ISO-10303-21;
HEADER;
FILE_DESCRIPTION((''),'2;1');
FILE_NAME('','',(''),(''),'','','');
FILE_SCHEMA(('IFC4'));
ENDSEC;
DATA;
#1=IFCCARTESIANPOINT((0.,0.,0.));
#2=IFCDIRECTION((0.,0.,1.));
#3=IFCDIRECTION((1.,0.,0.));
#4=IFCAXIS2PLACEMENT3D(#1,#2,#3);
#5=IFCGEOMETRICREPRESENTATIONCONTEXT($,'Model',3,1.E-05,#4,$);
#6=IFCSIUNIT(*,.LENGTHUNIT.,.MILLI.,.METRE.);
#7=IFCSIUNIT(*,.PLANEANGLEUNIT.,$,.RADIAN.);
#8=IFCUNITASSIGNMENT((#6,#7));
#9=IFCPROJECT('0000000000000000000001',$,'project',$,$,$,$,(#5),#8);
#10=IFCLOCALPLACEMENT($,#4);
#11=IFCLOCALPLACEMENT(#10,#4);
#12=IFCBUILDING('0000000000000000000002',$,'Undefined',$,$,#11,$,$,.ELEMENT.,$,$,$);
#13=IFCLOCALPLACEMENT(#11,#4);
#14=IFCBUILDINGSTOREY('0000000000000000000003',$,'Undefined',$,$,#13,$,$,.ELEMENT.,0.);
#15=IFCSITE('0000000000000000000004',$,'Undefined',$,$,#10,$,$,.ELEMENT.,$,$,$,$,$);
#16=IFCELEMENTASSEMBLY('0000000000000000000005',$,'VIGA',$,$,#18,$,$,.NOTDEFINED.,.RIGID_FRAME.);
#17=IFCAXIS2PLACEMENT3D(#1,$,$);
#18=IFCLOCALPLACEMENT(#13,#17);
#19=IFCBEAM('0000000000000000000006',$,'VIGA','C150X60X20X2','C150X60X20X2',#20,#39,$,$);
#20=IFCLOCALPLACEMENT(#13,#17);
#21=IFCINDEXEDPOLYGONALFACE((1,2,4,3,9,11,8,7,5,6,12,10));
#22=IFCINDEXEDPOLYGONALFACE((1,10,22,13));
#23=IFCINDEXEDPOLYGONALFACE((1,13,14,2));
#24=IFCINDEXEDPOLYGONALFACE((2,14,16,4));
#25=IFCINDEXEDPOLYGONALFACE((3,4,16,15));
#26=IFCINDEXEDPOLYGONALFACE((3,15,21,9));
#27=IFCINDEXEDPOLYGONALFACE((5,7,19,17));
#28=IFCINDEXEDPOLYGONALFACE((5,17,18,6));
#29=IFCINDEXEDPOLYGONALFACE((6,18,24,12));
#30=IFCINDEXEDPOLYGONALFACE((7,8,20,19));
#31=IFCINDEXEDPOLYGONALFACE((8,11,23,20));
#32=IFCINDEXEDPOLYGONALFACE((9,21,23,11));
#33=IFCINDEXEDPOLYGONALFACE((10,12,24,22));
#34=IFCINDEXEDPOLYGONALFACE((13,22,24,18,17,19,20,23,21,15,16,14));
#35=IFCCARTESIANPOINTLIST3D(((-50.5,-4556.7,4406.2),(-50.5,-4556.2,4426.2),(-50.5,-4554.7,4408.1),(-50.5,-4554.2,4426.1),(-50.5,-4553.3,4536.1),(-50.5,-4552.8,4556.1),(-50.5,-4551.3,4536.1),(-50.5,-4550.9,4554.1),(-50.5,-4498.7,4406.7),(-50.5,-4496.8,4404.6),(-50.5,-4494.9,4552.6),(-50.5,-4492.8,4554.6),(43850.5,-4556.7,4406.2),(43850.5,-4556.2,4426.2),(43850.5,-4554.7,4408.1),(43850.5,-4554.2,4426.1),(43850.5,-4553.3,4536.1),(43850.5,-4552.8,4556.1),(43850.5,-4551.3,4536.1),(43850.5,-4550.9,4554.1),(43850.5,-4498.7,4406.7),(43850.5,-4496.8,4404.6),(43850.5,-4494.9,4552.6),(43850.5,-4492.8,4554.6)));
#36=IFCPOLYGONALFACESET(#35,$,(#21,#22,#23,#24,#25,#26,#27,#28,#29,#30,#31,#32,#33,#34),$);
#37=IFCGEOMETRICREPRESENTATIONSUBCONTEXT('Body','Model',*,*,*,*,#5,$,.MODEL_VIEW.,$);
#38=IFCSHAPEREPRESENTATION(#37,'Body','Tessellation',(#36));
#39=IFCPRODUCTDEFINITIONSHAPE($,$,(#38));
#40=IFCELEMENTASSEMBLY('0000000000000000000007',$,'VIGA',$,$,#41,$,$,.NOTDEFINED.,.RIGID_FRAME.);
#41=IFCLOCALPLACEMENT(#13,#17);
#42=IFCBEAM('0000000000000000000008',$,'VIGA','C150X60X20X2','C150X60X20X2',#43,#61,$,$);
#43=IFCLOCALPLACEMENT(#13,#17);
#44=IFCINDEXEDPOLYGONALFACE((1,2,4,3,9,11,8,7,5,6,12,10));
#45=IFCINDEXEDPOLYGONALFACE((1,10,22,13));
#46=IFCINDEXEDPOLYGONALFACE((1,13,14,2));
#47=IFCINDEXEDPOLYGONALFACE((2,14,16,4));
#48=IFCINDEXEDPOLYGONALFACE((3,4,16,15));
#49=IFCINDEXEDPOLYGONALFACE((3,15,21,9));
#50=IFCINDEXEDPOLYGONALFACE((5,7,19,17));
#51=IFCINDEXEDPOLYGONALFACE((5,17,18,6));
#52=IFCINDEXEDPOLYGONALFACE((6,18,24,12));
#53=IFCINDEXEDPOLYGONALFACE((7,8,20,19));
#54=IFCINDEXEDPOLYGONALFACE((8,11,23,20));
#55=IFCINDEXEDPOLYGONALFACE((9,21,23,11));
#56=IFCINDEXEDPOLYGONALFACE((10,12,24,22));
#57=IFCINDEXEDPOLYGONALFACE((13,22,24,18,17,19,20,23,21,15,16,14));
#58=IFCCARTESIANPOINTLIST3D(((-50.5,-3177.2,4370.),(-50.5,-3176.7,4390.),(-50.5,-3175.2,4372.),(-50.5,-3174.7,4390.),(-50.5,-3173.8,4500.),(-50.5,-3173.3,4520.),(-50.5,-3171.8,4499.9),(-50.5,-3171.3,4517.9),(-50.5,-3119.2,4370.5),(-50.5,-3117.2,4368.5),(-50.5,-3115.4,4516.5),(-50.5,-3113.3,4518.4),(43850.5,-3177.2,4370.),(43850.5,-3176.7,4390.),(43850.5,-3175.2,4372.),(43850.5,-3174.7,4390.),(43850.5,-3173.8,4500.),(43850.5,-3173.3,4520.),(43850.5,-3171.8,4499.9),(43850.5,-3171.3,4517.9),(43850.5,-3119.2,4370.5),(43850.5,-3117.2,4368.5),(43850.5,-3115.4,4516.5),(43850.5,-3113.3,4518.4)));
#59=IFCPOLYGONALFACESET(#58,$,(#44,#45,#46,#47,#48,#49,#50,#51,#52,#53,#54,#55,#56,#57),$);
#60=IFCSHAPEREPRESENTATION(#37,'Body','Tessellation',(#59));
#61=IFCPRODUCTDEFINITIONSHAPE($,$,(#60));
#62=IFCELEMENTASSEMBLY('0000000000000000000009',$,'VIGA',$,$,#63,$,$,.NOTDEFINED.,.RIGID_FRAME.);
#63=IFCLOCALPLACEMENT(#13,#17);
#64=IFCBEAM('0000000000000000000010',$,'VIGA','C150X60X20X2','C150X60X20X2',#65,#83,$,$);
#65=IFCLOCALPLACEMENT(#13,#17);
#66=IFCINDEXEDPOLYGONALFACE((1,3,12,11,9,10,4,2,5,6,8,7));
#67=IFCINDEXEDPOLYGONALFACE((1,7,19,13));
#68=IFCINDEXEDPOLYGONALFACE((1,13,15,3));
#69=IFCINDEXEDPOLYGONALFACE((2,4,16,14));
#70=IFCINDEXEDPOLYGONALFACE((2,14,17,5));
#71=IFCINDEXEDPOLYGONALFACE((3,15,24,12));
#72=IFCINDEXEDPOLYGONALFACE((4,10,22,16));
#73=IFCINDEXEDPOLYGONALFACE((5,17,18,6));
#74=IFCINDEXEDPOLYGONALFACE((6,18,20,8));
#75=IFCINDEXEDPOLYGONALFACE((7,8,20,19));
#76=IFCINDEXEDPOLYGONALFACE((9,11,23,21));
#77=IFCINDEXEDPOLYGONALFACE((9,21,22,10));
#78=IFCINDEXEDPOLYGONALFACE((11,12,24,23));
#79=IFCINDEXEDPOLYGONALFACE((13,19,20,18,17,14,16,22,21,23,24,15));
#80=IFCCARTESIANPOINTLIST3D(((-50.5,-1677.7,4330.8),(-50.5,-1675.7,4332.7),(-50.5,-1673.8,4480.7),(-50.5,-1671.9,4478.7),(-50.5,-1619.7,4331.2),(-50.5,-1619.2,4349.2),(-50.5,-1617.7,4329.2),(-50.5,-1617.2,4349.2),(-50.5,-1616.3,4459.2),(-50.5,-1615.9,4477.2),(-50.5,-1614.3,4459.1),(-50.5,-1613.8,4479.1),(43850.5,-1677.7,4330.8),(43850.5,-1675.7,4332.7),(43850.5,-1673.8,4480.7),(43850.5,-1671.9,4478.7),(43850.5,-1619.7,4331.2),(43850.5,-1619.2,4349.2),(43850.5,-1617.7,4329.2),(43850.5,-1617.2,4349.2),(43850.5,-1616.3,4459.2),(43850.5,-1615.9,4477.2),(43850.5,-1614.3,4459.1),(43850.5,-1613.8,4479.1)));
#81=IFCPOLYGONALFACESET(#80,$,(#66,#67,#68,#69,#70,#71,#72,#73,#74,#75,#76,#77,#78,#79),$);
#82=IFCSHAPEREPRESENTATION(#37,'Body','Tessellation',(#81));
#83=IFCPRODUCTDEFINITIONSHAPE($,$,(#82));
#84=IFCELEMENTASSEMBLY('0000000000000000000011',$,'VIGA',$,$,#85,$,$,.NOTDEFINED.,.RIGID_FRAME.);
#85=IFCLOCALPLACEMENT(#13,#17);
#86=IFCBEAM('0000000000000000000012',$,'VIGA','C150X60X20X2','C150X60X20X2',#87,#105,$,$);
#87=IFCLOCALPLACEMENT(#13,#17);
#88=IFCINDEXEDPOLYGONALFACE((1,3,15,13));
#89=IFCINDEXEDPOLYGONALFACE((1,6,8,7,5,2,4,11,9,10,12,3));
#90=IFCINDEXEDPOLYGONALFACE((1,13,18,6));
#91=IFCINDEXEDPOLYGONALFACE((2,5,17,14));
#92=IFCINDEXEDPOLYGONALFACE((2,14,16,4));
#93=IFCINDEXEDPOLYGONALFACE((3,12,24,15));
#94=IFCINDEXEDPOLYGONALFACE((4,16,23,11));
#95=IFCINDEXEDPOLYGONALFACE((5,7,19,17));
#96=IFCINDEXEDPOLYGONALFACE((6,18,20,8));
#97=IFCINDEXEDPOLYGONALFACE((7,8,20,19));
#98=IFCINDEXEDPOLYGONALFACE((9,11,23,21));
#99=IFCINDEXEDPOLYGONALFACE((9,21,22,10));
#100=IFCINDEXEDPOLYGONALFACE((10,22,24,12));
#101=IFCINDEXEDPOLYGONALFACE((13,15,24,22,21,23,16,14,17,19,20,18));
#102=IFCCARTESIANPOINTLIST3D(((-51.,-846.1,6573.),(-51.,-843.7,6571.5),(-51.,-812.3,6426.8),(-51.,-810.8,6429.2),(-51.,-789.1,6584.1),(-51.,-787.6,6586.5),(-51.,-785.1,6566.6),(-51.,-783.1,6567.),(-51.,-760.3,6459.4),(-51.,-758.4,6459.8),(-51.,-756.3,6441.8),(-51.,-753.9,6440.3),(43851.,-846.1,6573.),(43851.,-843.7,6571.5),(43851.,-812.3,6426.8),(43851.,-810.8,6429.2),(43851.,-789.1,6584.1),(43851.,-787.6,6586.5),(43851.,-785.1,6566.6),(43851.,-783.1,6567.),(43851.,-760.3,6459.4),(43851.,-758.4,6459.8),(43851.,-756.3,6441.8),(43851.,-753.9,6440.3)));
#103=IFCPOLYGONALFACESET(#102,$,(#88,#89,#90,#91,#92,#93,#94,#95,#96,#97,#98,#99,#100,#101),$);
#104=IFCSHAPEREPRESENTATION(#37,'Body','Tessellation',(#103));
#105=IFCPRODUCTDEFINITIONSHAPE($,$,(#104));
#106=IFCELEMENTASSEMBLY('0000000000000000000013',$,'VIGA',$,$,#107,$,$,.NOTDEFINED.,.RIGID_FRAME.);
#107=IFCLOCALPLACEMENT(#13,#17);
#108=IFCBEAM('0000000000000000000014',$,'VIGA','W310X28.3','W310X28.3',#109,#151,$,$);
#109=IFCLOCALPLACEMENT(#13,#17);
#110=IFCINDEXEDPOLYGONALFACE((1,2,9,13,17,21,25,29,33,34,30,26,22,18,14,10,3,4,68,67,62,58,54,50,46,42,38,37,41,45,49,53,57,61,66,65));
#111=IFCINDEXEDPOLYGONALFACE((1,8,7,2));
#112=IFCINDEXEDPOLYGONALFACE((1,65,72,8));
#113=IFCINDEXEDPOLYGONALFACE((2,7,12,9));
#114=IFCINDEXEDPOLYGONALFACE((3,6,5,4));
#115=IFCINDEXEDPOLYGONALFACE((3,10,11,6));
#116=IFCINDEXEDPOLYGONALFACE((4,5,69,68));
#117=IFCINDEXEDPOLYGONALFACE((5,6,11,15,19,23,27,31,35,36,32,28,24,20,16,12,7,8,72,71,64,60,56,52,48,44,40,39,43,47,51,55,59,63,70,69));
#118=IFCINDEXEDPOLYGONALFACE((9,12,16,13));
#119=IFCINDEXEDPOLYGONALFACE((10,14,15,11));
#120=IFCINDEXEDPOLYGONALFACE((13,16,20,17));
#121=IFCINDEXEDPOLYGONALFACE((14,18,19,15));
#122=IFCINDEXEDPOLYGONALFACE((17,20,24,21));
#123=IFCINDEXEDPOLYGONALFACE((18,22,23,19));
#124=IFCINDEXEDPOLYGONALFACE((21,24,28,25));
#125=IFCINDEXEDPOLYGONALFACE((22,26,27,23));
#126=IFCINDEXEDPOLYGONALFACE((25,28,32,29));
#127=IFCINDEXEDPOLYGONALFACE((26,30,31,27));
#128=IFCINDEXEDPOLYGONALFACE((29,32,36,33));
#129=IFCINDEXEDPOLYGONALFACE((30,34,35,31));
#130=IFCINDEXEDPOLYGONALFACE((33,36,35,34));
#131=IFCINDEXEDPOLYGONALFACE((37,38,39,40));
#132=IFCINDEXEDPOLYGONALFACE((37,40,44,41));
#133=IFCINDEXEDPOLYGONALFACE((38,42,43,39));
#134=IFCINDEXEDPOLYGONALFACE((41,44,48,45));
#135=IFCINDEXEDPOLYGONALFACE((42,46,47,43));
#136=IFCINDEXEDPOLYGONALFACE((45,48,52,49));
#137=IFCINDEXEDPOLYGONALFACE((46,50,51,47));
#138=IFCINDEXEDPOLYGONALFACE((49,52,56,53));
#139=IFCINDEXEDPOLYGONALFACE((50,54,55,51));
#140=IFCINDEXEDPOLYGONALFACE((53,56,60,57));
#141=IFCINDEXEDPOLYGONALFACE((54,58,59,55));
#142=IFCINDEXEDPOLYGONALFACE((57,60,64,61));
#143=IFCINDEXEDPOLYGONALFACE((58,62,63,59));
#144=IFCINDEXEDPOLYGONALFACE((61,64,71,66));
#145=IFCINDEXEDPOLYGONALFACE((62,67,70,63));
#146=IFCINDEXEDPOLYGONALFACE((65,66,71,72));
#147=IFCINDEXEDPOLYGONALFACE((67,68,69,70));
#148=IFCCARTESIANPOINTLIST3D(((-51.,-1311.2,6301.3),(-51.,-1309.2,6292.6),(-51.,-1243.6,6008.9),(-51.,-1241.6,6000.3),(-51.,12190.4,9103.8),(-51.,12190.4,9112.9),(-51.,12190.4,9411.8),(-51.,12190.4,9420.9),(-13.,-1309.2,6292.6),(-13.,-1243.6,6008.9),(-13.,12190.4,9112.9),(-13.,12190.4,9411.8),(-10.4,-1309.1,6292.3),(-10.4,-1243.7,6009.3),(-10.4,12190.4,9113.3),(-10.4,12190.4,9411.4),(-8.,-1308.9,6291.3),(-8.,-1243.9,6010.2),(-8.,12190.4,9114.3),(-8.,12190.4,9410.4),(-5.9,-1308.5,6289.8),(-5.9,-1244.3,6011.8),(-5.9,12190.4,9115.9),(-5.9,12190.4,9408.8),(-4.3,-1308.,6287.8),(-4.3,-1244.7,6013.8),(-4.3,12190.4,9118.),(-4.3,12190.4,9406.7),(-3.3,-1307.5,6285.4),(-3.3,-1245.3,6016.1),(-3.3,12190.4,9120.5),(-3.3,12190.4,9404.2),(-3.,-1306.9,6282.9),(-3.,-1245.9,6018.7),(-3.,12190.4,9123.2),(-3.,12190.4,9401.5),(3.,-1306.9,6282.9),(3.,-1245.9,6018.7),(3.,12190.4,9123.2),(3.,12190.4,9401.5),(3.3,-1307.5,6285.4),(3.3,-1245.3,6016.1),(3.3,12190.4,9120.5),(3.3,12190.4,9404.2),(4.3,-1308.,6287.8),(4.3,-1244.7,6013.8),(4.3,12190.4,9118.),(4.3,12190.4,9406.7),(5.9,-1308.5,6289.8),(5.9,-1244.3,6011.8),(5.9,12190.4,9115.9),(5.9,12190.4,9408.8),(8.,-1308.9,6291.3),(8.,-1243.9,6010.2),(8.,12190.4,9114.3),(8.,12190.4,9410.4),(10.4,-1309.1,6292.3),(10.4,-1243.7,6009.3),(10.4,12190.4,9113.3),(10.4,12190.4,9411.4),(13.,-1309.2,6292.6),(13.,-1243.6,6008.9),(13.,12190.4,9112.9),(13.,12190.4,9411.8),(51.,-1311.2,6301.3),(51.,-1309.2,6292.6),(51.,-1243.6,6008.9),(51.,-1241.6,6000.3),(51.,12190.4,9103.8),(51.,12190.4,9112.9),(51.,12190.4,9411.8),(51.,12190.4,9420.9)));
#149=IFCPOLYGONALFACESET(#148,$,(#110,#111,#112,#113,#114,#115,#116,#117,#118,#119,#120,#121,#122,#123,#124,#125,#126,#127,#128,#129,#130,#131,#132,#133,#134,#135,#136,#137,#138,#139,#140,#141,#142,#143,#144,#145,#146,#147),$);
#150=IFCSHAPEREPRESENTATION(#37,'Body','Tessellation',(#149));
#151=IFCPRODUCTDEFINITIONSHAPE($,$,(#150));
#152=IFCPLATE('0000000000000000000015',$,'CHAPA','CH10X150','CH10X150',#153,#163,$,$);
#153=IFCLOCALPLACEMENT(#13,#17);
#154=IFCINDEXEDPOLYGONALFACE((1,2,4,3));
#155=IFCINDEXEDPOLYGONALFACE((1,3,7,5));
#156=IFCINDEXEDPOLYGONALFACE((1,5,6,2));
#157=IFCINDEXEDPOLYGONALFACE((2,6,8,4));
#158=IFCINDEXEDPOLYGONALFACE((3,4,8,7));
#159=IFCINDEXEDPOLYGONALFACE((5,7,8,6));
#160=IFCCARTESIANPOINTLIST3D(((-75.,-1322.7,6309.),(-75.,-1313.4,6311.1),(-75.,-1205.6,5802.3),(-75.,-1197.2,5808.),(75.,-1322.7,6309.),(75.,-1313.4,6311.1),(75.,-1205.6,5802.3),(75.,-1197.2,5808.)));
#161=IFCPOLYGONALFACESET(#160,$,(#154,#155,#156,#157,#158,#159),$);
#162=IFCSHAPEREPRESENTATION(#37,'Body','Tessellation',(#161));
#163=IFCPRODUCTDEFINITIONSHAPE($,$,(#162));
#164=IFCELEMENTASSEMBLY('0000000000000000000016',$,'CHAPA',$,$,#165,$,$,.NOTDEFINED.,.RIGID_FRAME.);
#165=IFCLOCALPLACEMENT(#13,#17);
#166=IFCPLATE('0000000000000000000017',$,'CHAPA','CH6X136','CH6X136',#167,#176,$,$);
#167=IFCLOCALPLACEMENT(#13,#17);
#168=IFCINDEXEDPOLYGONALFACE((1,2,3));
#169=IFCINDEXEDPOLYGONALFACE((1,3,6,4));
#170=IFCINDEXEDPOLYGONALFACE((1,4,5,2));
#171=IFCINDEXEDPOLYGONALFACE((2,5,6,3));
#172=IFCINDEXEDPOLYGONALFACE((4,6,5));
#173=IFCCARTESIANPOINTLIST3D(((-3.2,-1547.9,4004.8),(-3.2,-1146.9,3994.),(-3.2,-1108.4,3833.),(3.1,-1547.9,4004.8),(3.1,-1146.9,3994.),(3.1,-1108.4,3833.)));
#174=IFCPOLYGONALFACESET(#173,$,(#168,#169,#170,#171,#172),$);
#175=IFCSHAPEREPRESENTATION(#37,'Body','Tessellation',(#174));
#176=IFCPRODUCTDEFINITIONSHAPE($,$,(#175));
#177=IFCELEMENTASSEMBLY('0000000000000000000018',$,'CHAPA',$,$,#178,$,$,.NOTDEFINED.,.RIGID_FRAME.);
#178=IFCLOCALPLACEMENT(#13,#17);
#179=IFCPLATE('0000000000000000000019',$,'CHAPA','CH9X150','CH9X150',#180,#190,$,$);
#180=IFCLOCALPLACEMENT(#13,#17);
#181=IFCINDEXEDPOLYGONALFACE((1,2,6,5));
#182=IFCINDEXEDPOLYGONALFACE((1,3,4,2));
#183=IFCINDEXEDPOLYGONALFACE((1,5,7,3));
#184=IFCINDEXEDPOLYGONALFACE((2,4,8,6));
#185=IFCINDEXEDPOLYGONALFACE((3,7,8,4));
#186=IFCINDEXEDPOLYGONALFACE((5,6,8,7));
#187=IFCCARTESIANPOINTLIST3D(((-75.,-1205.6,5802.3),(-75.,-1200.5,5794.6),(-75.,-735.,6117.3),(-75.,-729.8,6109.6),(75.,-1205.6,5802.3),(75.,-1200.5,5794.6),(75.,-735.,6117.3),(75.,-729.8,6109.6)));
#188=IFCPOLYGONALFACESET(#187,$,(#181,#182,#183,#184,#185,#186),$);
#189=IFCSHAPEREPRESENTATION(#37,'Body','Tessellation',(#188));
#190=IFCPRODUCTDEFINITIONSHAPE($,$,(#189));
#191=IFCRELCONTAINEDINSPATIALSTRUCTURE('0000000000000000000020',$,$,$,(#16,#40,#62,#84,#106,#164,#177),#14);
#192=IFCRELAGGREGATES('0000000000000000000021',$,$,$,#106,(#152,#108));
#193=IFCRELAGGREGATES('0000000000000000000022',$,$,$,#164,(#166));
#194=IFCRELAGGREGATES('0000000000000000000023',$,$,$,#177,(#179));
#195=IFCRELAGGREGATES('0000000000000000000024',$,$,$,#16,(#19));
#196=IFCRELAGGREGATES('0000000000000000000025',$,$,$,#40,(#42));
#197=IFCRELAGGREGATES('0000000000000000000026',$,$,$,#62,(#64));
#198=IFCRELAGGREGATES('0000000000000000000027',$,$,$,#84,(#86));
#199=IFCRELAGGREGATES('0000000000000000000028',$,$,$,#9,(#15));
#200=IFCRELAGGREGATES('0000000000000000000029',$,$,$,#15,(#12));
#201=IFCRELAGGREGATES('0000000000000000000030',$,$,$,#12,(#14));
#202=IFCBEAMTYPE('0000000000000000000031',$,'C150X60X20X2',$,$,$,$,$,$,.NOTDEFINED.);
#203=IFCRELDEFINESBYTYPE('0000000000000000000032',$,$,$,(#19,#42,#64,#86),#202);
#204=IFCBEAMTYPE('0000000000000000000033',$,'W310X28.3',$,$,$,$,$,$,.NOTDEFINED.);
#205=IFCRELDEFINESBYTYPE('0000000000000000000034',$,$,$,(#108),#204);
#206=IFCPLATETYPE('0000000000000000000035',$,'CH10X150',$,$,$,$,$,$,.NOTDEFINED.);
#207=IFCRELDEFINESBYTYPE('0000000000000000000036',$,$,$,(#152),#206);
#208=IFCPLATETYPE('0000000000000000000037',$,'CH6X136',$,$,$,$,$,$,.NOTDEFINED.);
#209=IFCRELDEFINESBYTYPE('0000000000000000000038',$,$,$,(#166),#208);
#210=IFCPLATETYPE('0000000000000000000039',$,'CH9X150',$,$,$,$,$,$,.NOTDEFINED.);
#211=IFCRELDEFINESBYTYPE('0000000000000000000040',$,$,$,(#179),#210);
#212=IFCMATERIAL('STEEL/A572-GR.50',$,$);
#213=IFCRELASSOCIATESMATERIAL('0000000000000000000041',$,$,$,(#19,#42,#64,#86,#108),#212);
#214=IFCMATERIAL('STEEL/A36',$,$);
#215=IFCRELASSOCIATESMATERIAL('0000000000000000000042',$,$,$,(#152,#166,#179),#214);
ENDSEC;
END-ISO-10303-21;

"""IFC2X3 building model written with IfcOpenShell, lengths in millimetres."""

from ifc_helpers import new_model, si_unit, frame, origin_with_axes, origin_2d_with_axis, place, context, subcontext, project, spatial, polyline, i_section, c_section, outline, extrude, clip, halfspace, material, type_object, element, aggregate, save


model = new_model("IFC2X3")

# Units and contexts
model_context = context("Model", 3, precision=1e-05, world=origin_with_axes())
body_context = subcontext(model_context, "Body", "Model", "MODEL_VIEW")
ifc_project = project(units=[si_unit("LENGTHUNIT", "METRE", prefix="MILLI"), si_unit("PLANEANGLEUNIT", "RADIAN")], contexts=[model_context])

# Site, building, storey
site_placement = place(None, origin_with_axes())
site = spatial("IfcSite", under=ifc_project, at=site_placement, Name="Undefined", CompositionType="ELEMENT")
building_placement = place(site_placement, origin_with_axes())
building = spatial("IfcBuilding", under=site, at=building_placement, Name="Undefined", CompositionType="ELEMENT")
storey_placement = place(building_placement, origin_with_axes())
storey = spatial("IfcBuildingStorey", under=building, at=storey_placement, Name="Undefined", CompositionType="ELEMENT", Elevation=0.0)

# Element assemblies, beams
ifc_material_1 = material(Name="STEEL/A572-GR.50")
assembly_1_placement = place(storey_placement, origin_with_axes())
assembly_1 = element("IfcElementAssembly", 1, at=assembly_1_placement, inside=storey, Name="VIGA", AssemblyPlace="NOTDEFINED", PredefinedType="RIGID_FRAME")
beam_type_1 = type_object("IfcBeamType", Name="C150X60X20X2", PredefinedType="NOTDEFINED")
beam_1_placement = place(assembly_1_placement, frame((-50.5, -4524.8, 4480.4), z_axis=(0.0, 0.026187, 0.999657), x_axis=(1.0, 0.0, 0.0)))
beam_1 = element("IfcBeam", 2, at=beam_1_placement, type_object=beam_type_1, material=ifc_material_1, Name="VIGA", Description="C150X60X20X2", ObjectType="C150X60X20X2", context=body_context, shape_type="SweptSolid", body=[
    extrude(c_section(Depth=150.0, Width=60.0, WallThickness=2.0, Girth=20.0, at=origin_2d_with_axis()), frame((43901.0, 0.0, 0.0), z_axis=(-1.0, 0.0, 0.0), x_axis=(0.0, -1.0, 0.0)), (0.0, 0.0, 1.0), 43901.0),
])
assembly_2_placement = place(storey_placement, origin_with_axes())
assembly_2 = element("IfcElementAssembly", 3, at=assembly_2_placement, inside=storey, Name="VIGA", AssemblyPlace="NOTDEFINED", PredefinedType="RIGID_FRAME")
beam_2_placement = place(assembly_2_placement, frame((-50.5, -3145.3, 4444.2), z_axis=(0.0, 0.026187, 0.999657), x_axis=(1.0, 0.0, 0.0)))
beam_2 = element("IfcBeam", 4, at=beam_2_placement, type_object=beam_type_1, material=ifc_material_1, Name="VIGA", Description="C150X60X20X2", ObjectType="C150X60X20X2", context=body_context, shape_type="SweptSolid", body=[
    extrude(c_section(Depth=150.0, Width=60.0, WallThickness=2.0, Girth=20.0, at=origin_2d_with_axis()), frame((43901.0, 0.0, 0.0), z_axis=(-1.0, 0.0, 0.0), x_axis=(0.0, -1.0, 0.0)), (0.0, 0.0, 1.0), 43901.0),
])
assembly_3_placement = place(storey_placement, origin_with_axes())
assembly_3 = element("IfcElementAssembly", 5, at=assembly_3_placement, inside=storey, Name="VIGA", AssemblyPlace="NOTDEFINED", PredefinedType="RIGID_FRAME")
beam_3_placement = place(assembly_3_placement, frame((-50.5, -1645.8, 4404.9), z_axis=(0.0, -0.026187, -0.999657), x_axis=(1.0, 0.0, 0.0)))
beam_3 = element("IfcBeam", 6, at=beam_3_placement, type_object=beam_type_1, material=ifc_material_1, Name="VIGA", Description="C150X60X20X2", ObjectType="C150X60X20X2", context=body_context, shape_type="SweptSolid", body=[
    extrude(c_section(Depth=150.0, Width=60.0, WallThickness=2.0, Girth=20.0, at=origin_2d_with_axis()), frame((43901.0, 0.0, 0.0), z_axis=(-1.0, 0.0, 0.0), x_axis=(0.0, -1.0, 0.0)), (0.0, 0.0, 1.0), 43901.0),
])
assembly_4_placement = place(storey_placement, origin_with_axes())
assembly_4 = element("IfcElementAssembly", 7, at=assembly_4_placement, inside=storey, Name="VIGA", AssemblyPlace="NOTDEFINED", PredefinedType="RIGID_FRAME")
beam_4_placement = place(assembly_4_placement, frame((-51.0, -800.0, 6506.7), z_axis=(0.0, 0.225124, -0.97433), x_axis=(1.0, 0.0, 0.0)))
beam_4 = element("IfcBeam", 8, at=beam_4_placement, type_object=beam_type_1, material=ifc_material_1, Name="VIGA", Description="C150X60X20X2", ObjectType="C150X60X20X2", context=body_context, shape_type="SweptSolid", body=[
    extrude(c_section(Depth=150.0, Width=60.0, WallThickness=2.0, Girth=20.0, at=origin_2d_with_axis()), frame((43902.0, 0.0, 0.0), z_axis=(-1.0, 0.0, 0.0), x_axis=(0.0, -1.0, 0.0)), (0.0, 0.0, 1.0), 43902.0),
])
beam_type_2 = type_object("IfcBeamType", Name="W310X28.3", PredefinedType="NOTDEFINED")
assembly_5_placement = place(storey_placement, origin_with_axes())
assembly_5 = element("IfcElementAssembly", 9, at=assembly_5_placement, inside=storey, Name="VIGA", AssemblyPlace="NOTDEFINED", PredefinedType="RIGID_FRAME")
beam_5_placement = place(assembly_5_placement, frame((0.0, -1276.4, 6150.8), z_axis=(0.0, 0.225124, -0.97433), x_axis=(0.0, 0.97433, 0.225124)))
beam_5 = element("IfcBeam", 10, at=beam_5_placement, type_object=beam_type_2, material=ifc_material_1, Name="VIGA", Description="W310X28.3", ObjectType="W310X28.3", context=body_context, shape_type="Clipping", body=[
    clip(extrude(i_section(OverallWidth=102.0, OverallDepth=309.0, WebThickness=6.0, FlangeThickness=8.9, FilletRadius=10.0, at=origin_2d_with_axis()), frame((13995.7, 0.0, 0.0), z_axis=(-1.0, 0.0, 0.0), x_axis=(0.0, -1.0, 0.0)), (0.0, 0.0, 1.0), 13995.7), halfspace(frame((13857.8, 0.0, -156.7), z_axis=(0.97433, 0.0, 0.225124), x_axis=(-0.225124, 0.0, 0.97433)), False)),
])

# Plate
ifc_material_2 = material(Name="STEEL/A36")
plate_type_1 = type_object("IfcPlateType", Name="CH10X150", PredefinedType="NOTDEFINED")
plate_1_placement = place(assembly_5_placement, frame((75.0, -1318.1, 6310.1), z_axis=(0.0, 0.97433, 0.225124), x_axis=(0.0, 0.225124, -0.97433)))
plate_1 = element("IfcPlate", 11, at=plate_1_placement, type_object=plate_type_1, material=ifc_material_2, Name="CHAPA", Description="CH10X150", ObjectType="CH10X150", context=body_context, shape_type="Clipping", body=[
    clip(extrude(outline(polyline([(0.0, 0.0), (520.0, 0.0), (520.0, 150.0), (0.0, 150.0), (0.0, 0.0)])), frame((0.0, 0.0, -4.8), z_axis=(0.0, 0.0, 1.0), x_axis=(1.0, 0.0, 0.0)), (0.0, 0.0, 1.0), 9.5), halfspace(frame((516.4, -500.0, 4.8), z_axis=(0.934951, 0.0, 0.354778), x_axis=(0.0, 1.0, 0.0)), False)),
])
aggregate(assembly_5, [plate_1, beam_5])

# Element assemblies, plates
assembly_6_placement = place(storey_placement, origin_with_axes())
assembly_6 = element("IfcElementAssembly", 12, at=assembly_6_placement, inside=storey, Name="CHAPA", AssemblyPlace="NOTDEFINED", PredefinedType="RIGID_FRAME")
plate_type_2 = type_object("IfcPlateType", Name="CH6X136", PredefinedType="NOTDEFINED")
plate_2_placement = place(assembly_6_placement, frame((0.0, -1146.9, 3994.0), z_axis=(1.0, 0.0, 0.0), x_axis=(0.0, -0.999636, 0.026972)))
plate_2 = element("IfcPlate", 13, at=plate_2_placement, type_object=plate_type_2, material=ifc_material_2, Name="CHAPA", Description="CH6X136", ObjectType="CH6X136", context=body_context, shape_type="SweptSolid", body=[
    extrude(outline(polyline([(0.0, 0.0), (401.1, 0.0), (-42.8, 159.9), (0.0, 0.0)])), frame((0.0, 0.0, -3.1), z_axis=(0.0, 0.0, 1.0), x_axis=(1.0, 0.0, 0.0)), (0.0, 0.0, 1.0), 6.3),
])
aggregate(assembly_6, [plate_2])
assembly_7_placement = place(storey_placement, origin_with_axes())
assembly_7 = element("IfcElementAssembly", 14, at=assembly_7_placement, inside=storey, Name="CHAPA", AssemblyPlace="NOTDEFINED", PredefinedType="RIGID_FRAME")
plate_type_3 = type_object("IfcPlateType", Name="CH9X150", PredefinedType="NOTDEFINED")
plate_3_placement = place(assembly_7_placement, frame((75.0, -732.4, 6113.5), z_axis=(0.0, -0.55615, 0.831082), x_axis=(-1.0, 0.0, 0.0)))
plate_3 = element("IfcPlate", 15, at=plate_3_placement, type_object=plate_type_3, material=ifc_material_2, Name="CHAPA", Description="CH9X150", ObjectType="CH9X150", context=body_context, shape_type="SweptSolid", body=[
    extrude(outline(polyline([(0.0, 0.0), (150.0, 0.0), (150.0, 566.3), (0.0, 566.3), (0.0, 0.0)])), frame((0.0, 0.0, -4.7), z_axis=(0.0, 0.0, 1.0), x_axis=(1.0, 0.0, 0.0)), (0.0, 0.0, 1.0), 9.3),
])
aggregate(assembly_7, [plate_3])

aggregate(assembly_1, [beam_1])
aggregate(assembly_2, [beam_2])
aggregate(assembly_3, [beam_3])
aggregate(assembly_4, [beam_4])

save(model, "model.ifc")
